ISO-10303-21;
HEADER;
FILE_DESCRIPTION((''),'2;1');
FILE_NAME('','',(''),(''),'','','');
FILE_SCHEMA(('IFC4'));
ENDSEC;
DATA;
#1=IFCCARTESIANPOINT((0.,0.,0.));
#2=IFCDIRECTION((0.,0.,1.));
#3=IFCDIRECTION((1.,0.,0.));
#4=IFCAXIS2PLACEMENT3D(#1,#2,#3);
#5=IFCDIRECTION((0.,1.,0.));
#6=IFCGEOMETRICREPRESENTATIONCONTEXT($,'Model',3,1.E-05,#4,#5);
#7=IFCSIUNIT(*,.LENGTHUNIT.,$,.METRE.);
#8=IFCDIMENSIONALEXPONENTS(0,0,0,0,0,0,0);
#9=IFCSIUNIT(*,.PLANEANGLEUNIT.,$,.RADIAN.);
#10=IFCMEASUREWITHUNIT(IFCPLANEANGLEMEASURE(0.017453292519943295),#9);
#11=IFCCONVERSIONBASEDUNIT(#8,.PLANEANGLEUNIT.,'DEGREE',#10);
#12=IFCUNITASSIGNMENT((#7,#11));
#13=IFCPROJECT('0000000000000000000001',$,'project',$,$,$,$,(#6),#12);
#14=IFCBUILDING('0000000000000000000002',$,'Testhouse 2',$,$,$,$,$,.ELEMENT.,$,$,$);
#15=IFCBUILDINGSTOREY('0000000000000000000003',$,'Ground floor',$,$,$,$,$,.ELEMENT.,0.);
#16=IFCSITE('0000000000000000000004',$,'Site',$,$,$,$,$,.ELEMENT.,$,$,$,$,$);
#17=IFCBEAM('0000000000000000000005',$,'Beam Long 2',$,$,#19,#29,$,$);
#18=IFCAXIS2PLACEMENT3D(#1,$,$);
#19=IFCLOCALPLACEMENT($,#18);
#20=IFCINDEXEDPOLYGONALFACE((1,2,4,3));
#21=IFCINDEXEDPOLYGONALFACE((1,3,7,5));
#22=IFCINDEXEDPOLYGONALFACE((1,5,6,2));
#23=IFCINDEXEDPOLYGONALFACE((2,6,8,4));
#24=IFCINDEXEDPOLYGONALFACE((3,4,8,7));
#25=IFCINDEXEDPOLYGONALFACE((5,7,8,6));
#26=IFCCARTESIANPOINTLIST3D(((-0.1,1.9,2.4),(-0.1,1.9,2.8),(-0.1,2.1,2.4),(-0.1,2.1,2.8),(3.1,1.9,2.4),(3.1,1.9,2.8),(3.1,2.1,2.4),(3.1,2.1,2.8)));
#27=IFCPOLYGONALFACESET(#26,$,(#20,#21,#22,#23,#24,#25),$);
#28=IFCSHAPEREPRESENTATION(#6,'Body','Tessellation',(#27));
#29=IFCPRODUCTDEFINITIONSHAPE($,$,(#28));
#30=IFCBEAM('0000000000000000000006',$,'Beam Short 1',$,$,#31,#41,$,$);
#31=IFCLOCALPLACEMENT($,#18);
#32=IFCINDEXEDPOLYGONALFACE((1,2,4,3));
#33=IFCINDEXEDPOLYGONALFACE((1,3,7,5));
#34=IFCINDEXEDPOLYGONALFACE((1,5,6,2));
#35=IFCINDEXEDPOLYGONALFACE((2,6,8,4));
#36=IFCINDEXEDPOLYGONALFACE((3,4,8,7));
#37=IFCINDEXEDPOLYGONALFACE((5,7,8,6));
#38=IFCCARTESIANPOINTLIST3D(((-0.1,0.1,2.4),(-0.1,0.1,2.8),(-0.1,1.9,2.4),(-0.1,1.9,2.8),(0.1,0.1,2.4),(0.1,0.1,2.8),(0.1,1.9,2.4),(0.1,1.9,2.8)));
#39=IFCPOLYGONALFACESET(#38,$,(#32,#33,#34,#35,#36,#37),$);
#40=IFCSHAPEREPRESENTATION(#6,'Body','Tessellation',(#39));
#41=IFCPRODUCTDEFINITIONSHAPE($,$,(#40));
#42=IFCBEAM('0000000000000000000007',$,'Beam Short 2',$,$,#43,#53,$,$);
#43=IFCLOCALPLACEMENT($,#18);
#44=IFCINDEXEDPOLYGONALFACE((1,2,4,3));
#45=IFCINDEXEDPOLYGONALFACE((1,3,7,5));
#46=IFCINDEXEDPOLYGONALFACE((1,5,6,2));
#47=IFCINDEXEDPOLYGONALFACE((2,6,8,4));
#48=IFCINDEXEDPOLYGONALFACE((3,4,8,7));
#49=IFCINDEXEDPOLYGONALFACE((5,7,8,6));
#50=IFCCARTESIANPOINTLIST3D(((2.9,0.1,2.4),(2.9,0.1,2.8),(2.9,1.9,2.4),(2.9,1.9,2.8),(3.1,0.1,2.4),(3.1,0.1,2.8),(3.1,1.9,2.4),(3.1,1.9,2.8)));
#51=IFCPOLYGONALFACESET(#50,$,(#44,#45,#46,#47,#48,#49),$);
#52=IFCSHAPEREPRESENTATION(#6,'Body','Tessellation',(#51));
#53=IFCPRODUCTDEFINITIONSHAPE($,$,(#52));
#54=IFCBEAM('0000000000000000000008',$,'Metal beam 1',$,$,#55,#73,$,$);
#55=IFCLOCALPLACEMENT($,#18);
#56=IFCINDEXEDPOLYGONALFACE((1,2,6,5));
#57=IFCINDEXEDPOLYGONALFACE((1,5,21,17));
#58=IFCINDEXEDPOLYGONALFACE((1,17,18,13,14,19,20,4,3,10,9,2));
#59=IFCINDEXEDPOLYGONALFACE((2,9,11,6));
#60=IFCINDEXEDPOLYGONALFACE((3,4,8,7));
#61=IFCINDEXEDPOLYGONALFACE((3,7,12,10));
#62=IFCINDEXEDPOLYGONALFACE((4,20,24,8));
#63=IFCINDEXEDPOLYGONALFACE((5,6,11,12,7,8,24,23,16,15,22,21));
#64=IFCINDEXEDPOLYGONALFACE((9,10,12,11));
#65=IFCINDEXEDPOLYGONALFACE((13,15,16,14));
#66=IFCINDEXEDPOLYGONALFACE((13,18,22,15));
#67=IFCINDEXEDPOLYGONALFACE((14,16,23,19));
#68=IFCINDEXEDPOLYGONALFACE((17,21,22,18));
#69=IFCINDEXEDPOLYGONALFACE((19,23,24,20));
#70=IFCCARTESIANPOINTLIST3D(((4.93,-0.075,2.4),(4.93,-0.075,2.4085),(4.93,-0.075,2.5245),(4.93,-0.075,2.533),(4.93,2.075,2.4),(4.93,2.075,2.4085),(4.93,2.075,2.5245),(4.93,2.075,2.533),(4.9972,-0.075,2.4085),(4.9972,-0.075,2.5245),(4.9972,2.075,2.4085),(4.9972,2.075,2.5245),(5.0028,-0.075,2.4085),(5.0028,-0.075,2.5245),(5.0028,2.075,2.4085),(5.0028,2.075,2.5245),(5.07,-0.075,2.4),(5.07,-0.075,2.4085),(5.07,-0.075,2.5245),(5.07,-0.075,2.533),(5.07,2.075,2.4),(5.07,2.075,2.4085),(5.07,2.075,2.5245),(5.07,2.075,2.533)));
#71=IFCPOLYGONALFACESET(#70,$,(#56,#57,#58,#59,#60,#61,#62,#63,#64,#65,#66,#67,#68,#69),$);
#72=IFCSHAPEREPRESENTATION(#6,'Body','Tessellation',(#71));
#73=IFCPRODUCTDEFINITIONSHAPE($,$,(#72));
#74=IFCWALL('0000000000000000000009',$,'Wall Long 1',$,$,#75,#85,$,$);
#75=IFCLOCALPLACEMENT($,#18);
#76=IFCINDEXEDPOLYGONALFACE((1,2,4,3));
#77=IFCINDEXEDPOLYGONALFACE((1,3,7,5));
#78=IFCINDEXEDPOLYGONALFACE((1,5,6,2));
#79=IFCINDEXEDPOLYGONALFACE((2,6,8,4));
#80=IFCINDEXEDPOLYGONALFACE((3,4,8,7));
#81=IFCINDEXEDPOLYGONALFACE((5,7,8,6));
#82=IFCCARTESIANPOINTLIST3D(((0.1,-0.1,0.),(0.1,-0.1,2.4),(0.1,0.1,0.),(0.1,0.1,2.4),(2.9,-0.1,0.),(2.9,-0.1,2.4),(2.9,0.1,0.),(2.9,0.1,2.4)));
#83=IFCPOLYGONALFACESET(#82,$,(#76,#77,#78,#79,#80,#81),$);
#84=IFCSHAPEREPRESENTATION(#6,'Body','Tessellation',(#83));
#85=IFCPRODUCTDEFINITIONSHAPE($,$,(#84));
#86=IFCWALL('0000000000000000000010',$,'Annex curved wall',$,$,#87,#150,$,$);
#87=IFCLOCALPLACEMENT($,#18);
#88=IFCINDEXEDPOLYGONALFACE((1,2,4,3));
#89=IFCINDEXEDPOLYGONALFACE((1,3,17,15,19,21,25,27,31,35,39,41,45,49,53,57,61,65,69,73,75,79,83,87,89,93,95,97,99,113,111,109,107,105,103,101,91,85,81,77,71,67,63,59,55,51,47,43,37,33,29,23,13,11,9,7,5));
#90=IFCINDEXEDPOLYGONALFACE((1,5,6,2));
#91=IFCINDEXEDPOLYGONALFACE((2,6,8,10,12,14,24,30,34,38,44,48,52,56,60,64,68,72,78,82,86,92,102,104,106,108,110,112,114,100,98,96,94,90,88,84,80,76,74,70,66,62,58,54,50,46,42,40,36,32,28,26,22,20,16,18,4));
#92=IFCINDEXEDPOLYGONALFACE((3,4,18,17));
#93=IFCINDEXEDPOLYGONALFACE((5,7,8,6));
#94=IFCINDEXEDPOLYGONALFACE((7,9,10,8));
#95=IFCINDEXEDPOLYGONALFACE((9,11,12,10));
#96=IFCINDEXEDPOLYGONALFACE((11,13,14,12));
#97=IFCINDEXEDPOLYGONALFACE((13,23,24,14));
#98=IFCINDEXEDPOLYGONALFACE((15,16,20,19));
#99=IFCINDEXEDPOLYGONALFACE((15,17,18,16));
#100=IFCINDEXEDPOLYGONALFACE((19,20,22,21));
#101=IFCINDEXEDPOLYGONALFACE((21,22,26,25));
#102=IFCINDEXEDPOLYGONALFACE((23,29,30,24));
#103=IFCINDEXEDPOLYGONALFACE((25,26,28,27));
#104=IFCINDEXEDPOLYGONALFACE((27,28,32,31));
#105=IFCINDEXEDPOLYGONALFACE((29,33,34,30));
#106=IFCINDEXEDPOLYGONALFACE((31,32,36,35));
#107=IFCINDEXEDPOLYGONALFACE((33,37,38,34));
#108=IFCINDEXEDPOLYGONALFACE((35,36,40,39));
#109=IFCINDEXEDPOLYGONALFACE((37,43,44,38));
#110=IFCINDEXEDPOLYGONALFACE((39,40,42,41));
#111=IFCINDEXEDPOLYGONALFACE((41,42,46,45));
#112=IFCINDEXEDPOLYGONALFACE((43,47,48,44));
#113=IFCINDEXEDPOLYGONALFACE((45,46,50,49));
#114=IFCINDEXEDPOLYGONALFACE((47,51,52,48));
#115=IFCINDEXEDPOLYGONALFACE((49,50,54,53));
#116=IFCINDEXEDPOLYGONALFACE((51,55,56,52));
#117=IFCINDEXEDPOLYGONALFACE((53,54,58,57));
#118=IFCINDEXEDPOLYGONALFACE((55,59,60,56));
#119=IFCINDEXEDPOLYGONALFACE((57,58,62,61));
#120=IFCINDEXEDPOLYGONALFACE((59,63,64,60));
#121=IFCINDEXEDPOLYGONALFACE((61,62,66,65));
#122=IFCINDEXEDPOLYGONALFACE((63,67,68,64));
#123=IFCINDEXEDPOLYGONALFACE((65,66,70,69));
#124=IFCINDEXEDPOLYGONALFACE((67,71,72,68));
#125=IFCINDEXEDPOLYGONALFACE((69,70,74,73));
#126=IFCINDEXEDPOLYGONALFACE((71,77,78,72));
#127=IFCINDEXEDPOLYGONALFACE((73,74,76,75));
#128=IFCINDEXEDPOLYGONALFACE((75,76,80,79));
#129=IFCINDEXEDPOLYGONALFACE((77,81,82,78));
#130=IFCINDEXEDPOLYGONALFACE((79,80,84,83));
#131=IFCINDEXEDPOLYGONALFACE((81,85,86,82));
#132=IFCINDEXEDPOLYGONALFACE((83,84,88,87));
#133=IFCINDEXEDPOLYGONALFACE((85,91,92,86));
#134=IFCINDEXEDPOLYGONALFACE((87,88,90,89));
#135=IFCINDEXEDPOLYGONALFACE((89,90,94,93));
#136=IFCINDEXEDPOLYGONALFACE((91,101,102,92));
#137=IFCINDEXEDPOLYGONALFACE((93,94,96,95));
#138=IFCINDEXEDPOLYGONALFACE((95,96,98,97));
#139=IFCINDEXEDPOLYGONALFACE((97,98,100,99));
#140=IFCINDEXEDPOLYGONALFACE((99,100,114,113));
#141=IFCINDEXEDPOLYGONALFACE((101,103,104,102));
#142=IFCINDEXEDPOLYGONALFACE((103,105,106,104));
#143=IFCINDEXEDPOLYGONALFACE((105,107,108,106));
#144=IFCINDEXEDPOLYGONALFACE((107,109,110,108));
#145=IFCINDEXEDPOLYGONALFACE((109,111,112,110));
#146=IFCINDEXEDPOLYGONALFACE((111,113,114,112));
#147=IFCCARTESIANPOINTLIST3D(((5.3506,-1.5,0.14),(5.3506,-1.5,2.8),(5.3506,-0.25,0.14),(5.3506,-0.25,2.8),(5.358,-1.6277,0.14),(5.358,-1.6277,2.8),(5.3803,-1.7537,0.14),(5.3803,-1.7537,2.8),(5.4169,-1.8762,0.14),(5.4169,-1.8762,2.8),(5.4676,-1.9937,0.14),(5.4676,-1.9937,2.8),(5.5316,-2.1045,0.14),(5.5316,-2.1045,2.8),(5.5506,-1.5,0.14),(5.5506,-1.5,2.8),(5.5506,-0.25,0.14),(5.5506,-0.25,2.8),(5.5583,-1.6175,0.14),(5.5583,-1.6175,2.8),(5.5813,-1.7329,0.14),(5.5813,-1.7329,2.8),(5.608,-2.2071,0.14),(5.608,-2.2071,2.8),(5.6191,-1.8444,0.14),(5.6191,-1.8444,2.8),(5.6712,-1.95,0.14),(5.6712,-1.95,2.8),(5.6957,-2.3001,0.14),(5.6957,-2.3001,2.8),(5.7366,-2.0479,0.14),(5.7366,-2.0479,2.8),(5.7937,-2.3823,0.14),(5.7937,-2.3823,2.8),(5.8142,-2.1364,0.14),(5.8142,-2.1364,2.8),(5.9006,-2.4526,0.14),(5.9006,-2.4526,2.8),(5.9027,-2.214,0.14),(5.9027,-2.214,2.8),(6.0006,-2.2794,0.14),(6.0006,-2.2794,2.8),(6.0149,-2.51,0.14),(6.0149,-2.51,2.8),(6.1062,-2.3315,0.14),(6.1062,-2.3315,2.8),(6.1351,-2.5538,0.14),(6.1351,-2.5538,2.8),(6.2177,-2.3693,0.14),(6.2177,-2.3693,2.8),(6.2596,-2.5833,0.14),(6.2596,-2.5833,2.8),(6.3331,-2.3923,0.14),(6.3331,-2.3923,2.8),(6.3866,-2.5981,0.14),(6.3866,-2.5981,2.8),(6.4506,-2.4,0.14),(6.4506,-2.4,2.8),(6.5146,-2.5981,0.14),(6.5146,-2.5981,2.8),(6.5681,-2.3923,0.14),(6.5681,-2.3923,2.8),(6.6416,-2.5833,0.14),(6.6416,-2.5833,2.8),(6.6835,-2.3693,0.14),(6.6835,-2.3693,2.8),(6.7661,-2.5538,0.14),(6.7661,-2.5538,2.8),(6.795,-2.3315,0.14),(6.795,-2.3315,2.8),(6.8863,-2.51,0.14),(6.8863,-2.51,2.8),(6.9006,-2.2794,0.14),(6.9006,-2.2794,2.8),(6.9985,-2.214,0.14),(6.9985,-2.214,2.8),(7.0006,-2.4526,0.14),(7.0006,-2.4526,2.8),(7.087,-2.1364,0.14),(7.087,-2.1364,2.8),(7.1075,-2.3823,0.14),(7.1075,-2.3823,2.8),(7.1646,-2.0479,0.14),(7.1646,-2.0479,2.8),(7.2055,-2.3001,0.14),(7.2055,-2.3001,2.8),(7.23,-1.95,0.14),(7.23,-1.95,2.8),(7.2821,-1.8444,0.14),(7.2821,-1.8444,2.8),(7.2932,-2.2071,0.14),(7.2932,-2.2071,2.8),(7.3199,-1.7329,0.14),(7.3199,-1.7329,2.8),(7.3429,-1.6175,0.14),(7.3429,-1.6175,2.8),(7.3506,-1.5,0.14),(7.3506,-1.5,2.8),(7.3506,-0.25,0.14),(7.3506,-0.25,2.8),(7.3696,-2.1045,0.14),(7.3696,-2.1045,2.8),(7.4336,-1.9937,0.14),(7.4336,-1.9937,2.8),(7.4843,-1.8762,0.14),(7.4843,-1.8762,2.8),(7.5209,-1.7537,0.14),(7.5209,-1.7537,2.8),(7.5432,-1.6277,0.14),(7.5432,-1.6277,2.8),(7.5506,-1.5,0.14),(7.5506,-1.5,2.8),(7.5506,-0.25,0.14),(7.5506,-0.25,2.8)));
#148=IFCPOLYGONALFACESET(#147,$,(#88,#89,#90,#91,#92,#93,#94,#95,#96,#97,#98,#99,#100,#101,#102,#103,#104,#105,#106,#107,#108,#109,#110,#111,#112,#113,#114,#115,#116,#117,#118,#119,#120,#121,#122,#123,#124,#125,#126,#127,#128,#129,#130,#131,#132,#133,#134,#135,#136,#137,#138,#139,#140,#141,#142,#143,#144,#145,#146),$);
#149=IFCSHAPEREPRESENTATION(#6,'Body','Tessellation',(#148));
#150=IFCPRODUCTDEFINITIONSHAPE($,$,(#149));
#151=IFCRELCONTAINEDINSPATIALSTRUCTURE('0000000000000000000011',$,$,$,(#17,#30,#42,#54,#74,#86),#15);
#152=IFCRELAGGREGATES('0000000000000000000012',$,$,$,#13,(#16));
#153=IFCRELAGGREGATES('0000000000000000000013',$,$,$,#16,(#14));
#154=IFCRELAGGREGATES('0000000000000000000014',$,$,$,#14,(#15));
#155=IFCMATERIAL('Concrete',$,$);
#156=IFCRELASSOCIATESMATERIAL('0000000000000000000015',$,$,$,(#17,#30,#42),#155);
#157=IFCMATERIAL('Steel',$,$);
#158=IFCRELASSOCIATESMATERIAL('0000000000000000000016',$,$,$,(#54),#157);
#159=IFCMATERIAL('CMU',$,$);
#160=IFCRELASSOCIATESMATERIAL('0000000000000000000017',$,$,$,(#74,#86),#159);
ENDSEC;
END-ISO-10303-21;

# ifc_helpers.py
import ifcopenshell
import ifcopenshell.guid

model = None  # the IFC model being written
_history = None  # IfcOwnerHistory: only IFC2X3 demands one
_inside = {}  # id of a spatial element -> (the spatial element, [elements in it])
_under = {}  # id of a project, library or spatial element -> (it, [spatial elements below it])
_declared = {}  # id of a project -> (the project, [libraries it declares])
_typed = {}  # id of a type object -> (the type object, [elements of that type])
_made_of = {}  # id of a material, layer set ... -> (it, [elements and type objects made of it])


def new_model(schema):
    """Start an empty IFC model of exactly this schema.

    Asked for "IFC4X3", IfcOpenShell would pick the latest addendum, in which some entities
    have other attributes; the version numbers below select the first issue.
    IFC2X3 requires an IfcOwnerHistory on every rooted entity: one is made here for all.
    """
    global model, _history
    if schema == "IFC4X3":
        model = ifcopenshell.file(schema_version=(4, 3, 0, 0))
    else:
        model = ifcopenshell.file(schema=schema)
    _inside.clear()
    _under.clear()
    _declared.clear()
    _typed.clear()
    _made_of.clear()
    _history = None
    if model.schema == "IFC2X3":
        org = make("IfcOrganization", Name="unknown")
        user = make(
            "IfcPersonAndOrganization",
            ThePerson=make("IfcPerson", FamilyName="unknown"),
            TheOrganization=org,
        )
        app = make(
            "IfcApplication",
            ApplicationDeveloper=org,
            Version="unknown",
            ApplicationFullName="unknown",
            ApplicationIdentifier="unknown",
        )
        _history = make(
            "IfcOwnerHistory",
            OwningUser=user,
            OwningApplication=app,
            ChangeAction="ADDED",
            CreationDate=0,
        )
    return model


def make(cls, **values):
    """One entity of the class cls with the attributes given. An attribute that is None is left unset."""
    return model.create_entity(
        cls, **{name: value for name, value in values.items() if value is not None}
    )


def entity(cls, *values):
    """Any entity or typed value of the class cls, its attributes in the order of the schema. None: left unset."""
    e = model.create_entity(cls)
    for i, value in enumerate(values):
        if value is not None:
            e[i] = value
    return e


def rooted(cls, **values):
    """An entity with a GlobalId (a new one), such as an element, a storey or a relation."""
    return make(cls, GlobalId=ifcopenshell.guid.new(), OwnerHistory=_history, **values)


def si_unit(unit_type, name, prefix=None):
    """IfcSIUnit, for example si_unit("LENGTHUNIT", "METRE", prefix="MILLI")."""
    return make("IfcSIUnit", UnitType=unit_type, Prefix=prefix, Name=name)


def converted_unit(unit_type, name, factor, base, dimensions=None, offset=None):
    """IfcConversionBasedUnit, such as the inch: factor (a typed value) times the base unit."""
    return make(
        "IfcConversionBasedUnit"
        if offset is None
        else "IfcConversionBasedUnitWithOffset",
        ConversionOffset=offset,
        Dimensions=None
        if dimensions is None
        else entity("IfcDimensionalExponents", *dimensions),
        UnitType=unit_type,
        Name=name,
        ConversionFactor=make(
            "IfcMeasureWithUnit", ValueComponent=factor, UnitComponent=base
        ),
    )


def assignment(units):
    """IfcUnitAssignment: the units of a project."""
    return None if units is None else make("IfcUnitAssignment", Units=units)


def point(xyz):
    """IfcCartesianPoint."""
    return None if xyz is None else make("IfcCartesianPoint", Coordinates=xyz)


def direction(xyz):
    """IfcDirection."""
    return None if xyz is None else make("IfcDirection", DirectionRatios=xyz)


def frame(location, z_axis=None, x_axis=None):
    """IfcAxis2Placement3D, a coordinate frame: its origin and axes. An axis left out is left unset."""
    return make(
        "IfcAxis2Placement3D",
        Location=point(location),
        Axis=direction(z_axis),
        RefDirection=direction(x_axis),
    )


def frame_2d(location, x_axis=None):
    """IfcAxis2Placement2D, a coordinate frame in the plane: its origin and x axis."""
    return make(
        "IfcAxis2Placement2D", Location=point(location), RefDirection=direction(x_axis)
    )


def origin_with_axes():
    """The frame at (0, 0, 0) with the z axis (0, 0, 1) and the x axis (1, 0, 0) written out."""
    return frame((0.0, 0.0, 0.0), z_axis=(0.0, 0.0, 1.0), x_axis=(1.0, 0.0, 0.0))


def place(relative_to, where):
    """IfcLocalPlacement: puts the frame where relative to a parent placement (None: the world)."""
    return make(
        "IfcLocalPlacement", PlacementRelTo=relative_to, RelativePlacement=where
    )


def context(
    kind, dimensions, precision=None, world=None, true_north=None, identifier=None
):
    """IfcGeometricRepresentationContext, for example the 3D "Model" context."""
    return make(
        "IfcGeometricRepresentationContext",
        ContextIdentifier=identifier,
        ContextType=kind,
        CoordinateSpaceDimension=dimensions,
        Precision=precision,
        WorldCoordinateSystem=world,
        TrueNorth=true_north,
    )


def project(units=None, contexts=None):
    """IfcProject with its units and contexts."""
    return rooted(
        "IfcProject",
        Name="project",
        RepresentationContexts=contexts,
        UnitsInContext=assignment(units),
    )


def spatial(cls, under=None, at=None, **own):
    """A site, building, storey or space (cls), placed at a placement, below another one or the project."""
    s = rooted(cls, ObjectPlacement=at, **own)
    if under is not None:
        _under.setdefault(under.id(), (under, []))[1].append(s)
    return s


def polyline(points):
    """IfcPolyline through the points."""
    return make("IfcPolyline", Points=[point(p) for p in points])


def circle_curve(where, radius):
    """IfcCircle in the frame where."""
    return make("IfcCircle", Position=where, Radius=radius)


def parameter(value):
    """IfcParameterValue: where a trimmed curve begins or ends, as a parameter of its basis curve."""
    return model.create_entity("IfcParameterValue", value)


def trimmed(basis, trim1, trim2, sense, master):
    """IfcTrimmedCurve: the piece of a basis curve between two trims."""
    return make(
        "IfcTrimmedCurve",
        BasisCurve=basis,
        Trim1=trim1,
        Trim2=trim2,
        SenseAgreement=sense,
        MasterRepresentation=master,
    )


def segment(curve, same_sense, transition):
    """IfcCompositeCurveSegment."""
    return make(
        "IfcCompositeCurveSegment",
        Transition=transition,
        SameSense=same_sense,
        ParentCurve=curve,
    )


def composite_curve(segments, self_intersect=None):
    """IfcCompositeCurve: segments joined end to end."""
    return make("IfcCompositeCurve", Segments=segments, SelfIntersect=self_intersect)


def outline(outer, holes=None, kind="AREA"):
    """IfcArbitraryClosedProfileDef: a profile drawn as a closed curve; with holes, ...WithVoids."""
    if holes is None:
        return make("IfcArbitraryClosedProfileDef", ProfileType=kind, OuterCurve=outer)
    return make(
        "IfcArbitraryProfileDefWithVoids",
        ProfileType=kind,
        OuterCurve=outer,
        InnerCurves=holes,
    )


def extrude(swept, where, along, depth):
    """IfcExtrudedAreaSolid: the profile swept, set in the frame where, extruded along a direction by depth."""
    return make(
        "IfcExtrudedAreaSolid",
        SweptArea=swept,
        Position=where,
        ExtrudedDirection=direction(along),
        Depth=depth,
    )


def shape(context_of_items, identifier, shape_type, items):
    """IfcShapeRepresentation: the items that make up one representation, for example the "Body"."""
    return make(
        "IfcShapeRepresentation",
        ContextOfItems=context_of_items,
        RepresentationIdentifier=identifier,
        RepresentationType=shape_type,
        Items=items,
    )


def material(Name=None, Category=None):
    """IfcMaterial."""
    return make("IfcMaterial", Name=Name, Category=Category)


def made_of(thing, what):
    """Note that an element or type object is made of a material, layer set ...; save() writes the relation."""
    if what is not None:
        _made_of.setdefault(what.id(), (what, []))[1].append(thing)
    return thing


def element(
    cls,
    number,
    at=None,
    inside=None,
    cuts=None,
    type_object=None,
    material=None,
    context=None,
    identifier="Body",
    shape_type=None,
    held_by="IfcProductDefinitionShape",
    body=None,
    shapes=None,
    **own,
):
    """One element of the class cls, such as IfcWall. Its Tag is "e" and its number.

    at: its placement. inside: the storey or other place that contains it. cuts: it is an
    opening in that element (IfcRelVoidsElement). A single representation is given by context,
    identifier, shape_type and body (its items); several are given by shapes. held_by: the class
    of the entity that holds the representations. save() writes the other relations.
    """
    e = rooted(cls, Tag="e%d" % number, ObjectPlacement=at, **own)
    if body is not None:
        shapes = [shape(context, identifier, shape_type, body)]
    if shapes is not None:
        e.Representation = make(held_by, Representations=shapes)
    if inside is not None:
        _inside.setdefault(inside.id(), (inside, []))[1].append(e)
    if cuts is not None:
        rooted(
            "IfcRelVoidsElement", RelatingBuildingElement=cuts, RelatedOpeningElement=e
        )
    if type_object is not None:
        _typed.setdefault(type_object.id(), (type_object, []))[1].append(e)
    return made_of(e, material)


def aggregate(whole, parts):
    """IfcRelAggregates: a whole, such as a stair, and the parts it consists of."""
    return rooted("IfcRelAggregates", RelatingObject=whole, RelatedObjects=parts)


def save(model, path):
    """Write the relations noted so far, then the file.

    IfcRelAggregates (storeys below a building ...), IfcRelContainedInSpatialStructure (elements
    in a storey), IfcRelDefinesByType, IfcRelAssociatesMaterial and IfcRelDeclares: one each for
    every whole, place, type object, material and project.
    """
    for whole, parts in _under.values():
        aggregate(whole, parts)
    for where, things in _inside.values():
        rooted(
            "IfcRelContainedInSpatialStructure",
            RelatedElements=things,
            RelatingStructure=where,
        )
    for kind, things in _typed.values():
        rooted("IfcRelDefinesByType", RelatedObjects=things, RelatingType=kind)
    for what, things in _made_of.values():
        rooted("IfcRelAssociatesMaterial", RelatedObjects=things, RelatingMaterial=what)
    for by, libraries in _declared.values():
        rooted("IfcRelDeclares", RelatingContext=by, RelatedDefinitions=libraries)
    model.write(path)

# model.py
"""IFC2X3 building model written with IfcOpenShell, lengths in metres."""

from ifc_helpers import new_model, entity, si_unit, converted_unit, direction, frame, frame_2d, origin_with_axes, place, context, project, spatial, polyline, circle_curve, parameter, trimmed, segment, composite_curve, outline, extrude, material, element, save


model = new_model("IFC2X3")

# Units and contexts
model_context = context("Model", 3, precision=1e-05, world=origin_with_axes(), true_north=direction((0.0, 1.0, 0.0)))
ifc_project = project(units=[si_unit("LENGTHUNIT", "METRE"), converted_unit("PLANEANGLEUNIT", "DEGREE", entity("IfcPlaneAngleMeasure", 0.017453292519943295), si_unit("PLANEANGLEUNIT", "RADIAN"), dimensions=[0, 0, 0, 0, 0, 0, 0])], contexts=[model_context])

# Site, building, storey
site = spatial("IfcSite", under=ifc_project, Name="Site", CompositionType="ELEMENT")
building = spatial("IfcBuilding", under=site, Name="Testhouse 2", CompositionType="ELEMENT")
storey = spatial("IfcBuildingStorey", under=building, Name="Ground floor", CompositionType="ELEMENT", Elevation=0.0)

# Shared definitions
ifc_material_1 = material(Name="Concrete")
ifc_material_2 = material(Name="Steel")

# Beams
beam_1_placement = place(None, origin_with_axes())
element("IfcBeam", 1, at=beam_1_placement, inside=storey, material=ifc_material_1, Name="Beam Long 2", context=model_context, shape_type="SweptSolid", body=[
    extrude(outline(polyline([(-0.2, -0.1), (0.2, -0.1), (0.2, 0.1), (-0.2, 0.1), (-0.2, -0.1)])), frame((-0.1, 2.0, 2.6), z_axis=(1.0, 0.0, 0.0), x_axis=(0.0, 0.0, -1.0)), (0.0, 0.0, 1.0), 3.2),
])
beam_2_placement = place(None, origin_with_axes())
element("IfcBeam", 2, at=beam_2_placement, inside=storey, material=ifc_material_1, Name="Beam Short 1", context=model_context, shape_type="SweptSolid", body=[
    extrude(outline(polyline([(-0.2, -0.1), (0.2, -0.1), (0.2, 0.1), (-0.2, 0.1), (-0.2, -0.1)])), frame((0.0, 0.1, 2.6), z_axis=(0.0, 1.0, 0.0), x_axis=(0.0, 0.0, -1.0)), (0.0, 0.0, 1.0), 1.8),
])
beam_3_placement = place(None, origin_with_axes())
element("IfcBeam", 3, at=beam_3_placement, inside=storey, material=ifc_material_1, Name="Beam Short 2", context=model_context, shape_type="SweptSolid", body=[
    extrude(outline(polyline([(-0.2, -0.1), (0.2, -0.1), (0.2, 0.1), (-0.2, 0.1), (-0.2, -0.1)])), frame((3.0, 0.1, 2.6), z_axis=(0.0, 1.0, 0.0), x_axis=(0.0, 0.0, -1.0)), (0.0, 0.0, 1.0), 1.8),
])
beam_4_placement = place(None, origin_with_axes())
element("IfcBeam", 4, at=beam_4_placement, inside=storey, material=ifc_material_2, Name="Metal beam 1", context=model_context, shape_type="SweptSolid", body=[
    extrude(outline(polyline([(-0.07, -0.0665), (0.07, -0.0665), (0.07, -0.058), (0.0027, -0.058), (0.0027, 0.058), (0.07, 0.058), (0.07, 0.0665), (-0.07, 0.0665), (-0.07, 0.058), (-0.0027, 0.058), (-0.0027, -0.058), (-0.07, -0.058), (-0.07, -0.0665)])), frame((5.0, 2.075, 2.4665), z_axis=(0.0, -1.0, 0.0), x_axis=(1.0, 0.0, 0.0)), (0.0, 0.0, 1.0), 2.15),
])

# Walls
ifc_material_3 = material(Name="CMU")
wall_1_placement = place(None, origin_with_axes())
element("IfcWall", 5, at=wall_1_placement, inside=storey, material=ifc_material_3, Name="Wall Long 1", context=model_context, shape_type="SweptSolid", body=[
    extrude(outline(polyline([(0.1, -0.1), (0.1, 0.1), (2.9, 0.1), (2.9, -0.1), (0.1, -0.1)])), origin_with_axes(), (0.0, 0.0, 1.0), 2.4),
])
wall_2_placement = place(None, origin_with_axes())
element("IfcWall", 6, at=wall_2_placement, inside=storey, material=ifc_material_3, Name="Annex curved wall", context=model_context, shape_type="SweptSolid", body=[
    extrude(outline(composite_curve([segment(polyline([(5.3506, -0.25), (5.5506, -0.25)]), True, "CONTINUOUS"), segment(polyline([(5.5506, -0.25), (5.5506, -1.5)]), True, "CONTINUOUS"), segment(trimmed(circle_curve(frame_2d((6.4506, -1.5), x_axis=(1.0, 0.0)), 0.9), [parameter(180.0)], [parameter(0.0)], True, "PARAMETER"), True, "CONTINUOUS"), segment(polyline([(7.3506, -1.5), (7.3506, -0.25)]), True, "CONTINUOUS"), segment(polyline([(7.3506, -0.25), (7.5506, -0.25)]), True, "CONTINUOUS"), segment(polyline([(7.5506, -0.25), (7.5506, -1.5)]), True, "CONTINUOUS"), segment(trimmed(circle_curve(frame_2d((6.4506, -1.5), x_axis=(1.0, 0.0)), 1.1), [parameter(0.0)], [parameter(180.0)], False, "PARAMETER"), True, "CONTINUOUS"), segment(polyline([(5.3506, -1.5), (5.3506, -0.25)]), True, "CONTINUOUS")], self_intersect=False)), frame((0.0, 0.0, 0.14), z_axis=(0.0, 0.0, 1.0), x_axis=(1.0, 0.0, 0.0)), (0.0, 0.0, 1.0), 2.66),
])

save(model, "model.ifc")
